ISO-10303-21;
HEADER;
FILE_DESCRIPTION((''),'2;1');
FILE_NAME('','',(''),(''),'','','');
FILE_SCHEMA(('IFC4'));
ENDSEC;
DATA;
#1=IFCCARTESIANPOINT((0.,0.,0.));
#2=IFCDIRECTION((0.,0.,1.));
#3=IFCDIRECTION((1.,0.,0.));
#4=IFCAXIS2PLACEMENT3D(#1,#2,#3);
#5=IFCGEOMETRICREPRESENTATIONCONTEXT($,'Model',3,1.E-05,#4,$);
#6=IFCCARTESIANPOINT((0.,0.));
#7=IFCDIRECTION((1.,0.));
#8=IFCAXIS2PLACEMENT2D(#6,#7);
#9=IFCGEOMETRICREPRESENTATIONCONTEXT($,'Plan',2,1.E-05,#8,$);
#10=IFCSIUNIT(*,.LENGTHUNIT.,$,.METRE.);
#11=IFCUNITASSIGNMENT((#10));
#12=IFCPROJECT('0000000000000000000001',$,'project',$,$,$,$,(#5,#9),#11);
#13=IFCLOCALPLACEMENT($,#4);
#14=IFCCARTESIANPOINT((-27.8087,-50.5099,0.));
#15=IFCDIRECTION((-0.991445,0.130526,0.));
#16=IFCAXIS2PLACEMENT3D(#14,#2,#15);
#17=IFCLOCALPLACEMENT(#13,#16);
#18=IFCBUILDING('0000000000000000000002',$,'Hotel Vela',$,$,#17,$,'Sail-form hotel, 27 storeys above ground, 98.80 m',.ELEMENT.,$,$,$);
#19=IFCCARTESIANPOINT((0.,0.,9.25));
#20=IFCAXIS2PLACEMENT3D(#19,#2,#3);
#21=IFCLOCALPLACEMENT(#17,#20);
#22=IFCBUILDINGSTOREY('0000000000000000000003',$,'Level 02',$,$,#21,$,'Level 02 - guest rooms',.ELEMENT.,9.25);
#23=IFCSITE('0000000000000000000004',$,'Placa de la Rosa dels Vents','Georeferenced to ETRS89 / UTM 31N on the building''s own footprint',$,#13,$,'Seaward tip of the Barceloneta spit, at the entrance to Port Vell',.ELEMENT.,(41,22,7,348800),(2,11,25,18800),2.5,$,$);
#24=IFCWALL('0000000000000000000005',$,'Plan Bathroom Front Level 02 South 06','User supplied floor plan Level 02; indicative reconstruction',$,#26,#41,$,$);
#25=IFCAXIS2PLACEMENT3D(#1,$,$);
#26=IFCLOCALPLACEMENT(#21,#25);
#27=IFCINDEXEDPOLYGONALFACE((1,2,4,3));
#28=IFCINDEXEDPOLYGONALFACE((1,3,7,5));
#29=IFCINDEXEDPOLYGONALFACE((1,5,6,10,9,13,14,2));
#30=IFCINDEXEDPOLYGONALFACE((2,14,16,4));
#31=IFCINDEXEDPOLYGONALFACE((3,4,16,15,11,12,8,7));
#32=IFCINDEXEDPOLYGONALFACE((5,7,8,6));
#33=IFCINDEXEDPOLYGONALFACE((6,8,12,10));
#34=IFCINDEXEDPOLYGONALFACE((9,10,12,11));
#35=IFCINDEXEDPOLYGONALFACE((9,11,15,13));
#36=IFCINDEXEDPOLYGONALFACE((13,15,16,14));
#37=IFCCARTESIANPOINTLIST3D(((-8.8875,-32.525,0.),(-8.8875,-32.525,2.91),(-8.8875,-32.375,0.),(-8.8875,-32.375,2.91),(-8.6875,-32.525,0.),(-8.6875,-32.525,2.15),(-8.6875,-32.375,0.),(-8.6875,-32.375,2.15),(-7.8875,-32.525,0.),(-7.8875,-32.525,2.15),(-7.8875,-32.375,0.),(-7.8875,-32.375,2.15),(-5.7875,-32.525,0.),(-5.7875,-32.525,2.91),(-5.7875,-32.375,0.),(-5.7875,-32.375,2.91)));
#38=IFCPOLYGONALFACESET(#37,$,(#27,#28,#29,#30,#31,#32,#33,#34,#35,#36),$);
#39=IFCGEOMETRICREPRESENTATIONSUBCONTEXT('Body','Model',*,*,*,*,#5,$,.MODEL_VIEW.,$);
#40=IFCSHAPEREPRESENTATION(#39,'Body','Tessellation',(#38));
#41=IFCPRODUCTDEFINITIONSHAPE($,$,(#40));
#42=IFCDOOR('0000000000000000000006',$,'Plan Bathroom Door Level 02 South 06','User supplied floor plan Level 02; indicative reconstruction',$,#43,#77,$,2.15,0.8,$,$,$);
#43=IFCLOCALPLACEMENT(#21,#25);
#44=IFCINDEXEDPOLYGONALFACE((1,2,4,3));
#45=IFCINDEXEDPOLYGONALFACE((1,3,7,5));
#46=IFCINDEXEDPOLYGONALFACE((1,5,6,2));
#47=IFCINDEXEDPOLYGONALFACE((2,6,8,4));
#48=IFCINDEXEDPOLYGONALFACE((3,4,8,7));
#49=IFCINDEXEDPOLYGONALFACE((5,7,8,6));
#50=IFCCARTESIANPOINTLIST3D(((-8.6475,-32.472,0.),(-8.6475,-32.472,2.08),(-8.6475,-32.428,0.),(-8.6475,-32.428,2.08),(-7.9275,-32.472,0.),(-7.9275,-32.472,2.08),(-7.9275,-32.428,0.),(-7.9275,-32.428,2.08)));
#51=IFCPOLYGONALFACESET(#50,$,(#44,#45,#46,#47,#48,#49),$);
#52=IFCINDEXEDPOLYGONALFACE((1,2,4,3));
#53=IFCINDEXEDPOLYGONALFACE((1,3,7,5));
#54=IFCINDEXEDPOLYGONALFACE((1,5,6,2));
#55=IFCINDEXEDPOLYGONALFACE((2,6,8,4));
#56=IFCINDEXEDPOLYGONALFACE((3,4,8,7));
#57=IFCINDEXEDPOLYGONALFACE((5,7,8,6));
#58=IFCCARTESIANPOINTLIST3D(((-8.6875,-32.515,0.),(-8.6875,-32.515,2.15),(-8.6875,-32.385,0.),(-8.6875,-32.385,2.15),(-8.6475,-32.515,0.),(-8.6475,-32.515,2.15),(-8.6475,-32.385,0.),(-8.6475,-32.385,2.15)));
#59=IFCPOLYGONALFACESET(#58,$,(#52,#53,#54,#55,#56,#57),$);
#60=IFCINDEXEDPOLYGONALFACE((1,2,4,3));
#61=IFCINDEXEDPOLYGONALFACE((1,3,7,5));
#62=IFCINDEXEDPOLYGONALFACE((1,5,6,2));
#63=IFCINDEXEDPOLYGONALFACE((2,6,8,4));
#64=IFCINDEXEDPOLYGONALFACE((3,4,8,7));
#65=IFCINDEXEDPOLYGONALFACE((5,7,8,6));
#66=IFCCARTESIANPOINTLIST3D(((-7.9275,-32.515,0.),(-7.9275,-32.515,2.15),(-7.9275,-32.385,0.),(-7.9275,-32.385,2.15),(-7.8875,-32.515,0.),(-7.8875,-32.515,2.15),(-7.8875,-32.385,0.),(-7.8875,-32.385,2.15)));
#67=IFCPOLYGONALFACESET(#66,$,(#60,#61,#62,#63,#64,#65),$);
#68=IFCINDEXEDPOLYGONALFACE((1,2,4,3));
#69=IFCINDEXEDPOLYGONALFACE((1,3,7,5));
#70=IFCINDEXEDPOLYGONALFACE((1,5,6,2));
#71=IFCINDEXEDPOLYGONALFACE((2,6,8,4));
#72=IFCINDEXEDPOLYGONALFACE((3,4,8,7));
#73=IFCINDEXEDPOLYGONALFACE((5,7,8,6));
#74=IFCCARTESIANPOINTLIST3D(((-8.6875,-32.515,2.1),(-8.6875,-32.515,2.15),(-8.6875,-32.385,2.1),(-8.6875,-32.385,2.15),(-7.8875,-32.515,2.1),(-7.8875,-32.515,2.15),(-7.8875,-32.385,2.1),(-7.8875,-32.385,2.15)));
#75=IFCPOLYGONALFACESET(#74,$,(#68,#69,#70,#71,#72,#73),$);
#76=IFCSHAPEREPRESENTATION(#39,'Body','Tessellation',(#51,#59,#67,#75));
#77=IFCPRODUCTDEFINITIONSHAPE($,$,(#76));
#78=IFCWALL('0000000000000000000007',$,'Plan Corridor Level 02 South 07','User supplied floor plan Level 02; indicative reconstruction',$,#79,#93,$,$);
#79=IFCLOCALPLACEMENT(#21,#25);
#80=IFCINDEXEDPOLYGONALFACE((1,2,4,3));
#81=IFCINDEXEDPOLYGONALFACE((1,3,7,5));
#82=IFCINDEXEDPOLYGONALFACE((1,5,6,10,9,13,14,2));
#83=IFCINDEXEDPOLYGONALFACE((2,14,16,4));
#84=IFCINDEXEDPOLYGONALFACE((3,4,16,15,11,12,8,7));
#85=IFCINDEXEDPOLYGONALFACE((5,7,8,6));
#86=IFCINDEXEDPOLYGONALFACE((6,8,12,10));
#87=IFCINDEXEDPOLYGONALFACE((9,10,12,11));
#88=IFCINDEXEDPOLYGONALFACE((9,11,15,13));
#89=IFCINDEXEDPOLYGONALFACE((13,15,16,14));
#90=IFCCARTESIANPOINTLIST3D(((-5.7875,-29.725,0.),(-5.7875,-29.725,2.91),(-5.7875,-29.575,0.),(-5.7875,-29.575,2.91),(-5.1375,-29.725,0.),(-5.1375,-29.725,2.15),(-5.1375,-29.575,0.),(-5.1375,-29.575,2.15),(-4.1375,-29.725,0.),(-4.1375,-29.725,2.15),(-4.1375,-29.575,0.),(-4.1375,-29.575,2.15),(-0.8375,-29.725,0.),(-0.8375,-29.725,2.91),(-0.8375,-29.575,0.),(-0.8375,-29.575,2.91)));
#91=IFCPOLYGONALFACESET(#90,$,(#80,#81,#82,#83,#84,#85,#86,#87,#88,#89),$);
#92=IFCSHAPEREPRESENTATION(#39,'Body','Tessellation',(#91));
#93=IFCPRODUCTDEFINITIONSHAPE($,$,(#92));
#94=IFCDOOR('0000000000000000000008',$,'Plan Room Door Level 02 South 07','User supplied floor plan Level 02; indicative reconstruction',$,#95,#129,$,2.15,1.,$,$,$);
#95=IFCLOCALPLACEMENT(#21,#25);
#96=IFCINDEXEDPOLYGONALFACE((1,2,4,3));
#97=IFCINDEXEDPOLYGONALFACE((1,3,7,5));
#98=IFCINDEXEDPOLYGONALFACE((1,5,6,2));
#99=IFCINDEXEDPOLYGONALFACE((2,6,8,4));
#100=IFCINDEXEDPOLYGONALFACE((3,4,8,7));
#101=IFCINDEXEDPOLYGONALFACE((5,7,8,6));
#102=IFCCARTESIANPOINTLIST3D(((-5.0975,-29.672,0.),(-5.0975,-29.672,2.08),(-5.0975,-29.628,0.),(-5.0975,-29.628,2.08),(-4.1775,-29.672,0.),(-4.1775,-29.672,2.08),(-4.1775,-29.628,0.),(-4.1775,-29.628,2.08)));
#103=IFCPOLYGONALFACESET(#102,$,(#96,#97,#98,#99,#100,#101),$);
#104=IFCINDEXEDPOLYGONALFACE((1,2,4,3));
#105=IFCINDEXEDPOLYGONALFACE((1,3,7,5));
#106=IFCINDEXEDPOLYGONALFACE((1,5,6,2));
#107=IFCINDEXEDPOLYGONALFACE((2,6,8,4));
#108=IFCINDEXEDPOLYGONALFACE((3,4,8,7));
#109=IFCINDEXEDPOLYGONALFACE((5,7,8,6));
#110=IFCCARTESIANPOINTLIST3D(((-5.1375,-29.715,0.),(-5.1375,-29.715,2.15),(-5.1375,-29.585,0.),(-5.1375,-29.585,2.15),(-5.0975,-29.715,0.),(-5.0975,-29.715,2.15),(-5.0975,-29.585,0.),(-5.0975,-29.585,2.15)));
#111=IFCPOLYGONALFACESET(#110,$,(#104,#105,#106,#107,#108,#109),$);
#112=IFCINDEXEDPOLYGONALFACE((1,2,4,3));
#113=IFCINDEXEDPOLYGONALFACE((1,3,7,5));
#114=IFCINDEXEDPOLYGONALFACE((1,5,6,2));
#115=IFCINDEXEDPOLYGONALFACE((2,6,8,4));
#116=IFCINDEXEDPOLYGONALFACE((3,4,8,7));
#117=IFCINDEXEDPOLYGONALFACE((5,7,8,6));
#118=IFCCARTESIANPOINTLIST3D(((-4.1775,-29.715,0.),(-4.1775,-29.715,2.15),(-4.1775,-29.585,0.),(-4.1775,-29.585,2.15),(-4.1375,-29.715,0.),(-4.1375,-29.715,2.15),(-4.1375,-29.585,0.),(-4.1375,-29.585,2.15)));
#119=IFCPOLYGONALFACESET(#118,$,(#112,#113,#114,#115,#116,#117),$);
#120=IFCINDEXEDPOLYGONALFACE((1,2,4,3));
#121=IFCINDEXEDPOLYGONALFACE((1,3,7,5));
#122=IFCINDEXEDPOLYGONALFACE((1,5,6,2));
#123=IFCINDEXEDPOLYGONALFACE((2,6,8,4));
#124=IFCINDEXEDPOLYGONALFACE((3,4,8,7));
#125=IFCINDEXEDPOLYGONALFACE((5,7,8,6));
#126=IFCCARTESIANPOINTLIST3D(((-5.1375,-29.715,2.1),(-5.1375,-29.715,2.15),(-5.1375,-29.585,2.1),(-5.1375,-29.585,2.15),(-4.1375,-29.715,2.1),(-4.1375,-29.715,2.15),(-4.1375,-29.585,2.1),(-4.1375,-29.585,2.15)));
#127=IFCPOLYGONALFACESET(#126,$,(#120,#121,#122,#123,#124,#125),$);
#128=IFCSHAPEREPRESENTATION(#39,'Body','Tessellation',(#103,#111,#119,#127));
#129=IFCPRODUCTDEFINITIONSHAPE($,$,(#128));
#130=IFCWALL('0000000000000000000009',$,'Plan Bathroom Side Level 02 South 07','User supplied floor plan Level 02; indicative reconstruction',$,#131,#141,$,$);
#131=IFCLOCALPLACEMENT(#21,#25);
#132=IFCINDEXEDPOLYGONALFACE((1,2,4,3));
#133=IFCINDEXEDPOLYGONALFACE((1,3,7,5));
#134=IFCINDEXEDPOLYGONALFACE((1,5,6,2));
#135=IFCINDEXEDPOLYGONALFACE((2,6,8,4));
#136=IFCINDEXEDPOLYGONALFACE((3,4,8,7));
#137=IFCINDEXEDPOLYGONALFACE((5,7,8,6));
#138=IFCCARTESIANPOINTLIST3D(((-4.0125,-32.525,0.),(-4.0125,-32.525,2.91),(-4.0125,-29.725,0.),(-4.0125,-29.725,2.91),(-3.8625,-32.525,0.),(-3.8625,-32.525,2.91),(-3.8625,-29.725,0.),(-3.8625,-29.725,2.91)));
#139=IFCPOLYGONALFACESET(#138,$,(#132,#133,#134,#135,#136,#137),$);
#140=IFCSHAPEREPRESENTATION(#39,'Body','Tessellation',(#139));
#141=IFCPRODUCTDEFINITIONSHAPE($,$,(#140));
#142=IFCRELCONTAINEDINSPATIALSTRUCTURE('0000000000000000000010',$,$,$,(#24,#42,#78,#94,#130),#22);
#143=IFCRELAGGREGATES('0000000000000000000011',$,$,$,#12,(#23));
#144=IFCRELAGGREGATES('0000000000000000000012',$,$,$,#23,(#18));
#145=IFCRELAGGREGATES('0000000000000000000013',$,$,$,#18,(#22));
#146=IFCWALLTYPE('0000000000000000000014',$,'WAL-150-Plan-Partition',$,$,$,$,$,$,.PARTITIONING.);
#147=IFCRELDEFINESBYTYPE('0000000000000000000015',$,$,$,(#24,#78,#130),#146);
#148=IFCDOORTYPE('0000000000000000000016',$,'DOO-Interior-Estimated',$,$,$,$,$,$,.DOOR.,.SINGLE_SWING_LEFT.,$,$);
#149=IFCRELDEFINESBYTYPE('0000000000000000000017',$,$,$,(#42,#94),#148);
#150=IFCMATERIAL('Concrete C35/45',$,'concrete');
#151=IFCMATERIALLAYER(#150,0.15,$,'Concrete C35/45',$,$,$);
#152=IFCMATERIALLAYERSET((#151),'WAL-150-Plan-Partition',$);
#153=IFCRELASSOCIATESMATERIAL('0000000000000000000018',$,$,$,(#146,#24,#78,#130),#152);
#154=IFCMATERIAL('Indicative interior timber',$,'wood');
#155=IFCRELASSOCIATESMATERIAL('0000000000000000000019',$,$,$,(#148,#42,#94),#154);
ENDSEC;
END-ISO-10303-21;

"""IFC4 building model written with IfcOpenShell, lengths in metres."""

from ifc_helpers import new_model, si_unit, frame, origin_with_axes, origin_2d_with_axis, place, context, subcontext, project, spatial, line, indexed_curve, outline, extrude, material, layer, layer_set, layer_usage, type_object, element, fill, save


model = new_model("IFC4")

# Units and contexts
model_context = context("Model", 3, precision=1e-05, world=origin_with_axes())
plan_context = context("Plan", 2, precision=1e-05, world=origin_2d_with_axis())
body_context = subcontext(model_context, "Body", "Model", "MODEL_VIEW")
ifc_project = project(units=[si_unit("LENGTHUNIT", "METRE")], contexts=[model_context, plan_context])

# Site, building, storey
site_placement = place(None, origin_with_axes())
site = spatial("IfcSite", under=ifc_project, at=site_placement, Name="Placa de la Rosa dels Vents", Description="Georeferenced to ETRS89 / UTM 31N on the building's own footprint", LongName="Seaward tip of the Barceloneta spit, at the entrance to Port Vell", CompositionType="ELEMENT", RefLatitude=(41, 22, 7, 348800), RefLongitude=(2, 11, 25, 18800), RefElevation=2.5)
building_placement = place(site_placement, frame((-27.8087, -50.5099, 0.0), z_axis=(0.0, 0.0, 1.0), x_axis=(-0.991445, 0.130526, 0.0)))
building = spatial("IfcBuilding", under=site, at=building_placement, Name="Hotel Vela", LongName="Sail-form hotel, 27 storeys above ground, 98.80 m", CompositionType="ELEMENT")
storey_placement = place(building_placement, frame((0.0, 0.0, 9.25), z_axis=(0.0, 0.0, 1.0), x_axis=(1.0, 0.0, 0.0)))
storey = spatial("IfcBuildingStorey", under=building, at=storey_placement, Name="Level 02", LongName="Level 02 - guest rooms", CompositionType="ELEMENT", Elevation=9.25)

# Shared definitions
ifc_material_1 = material(Name="Concrete C35/45", Category="concrete")
ifc_layer = layer(ifc_material_1, 0.15, Name="Concrete C35/45")
ifc_layer_set = layer_set([ifc_layer], Name="WAL-150-Plan-Partition")
wall_type = type_object("IfcWallType", Name="WAL-150-Plan-Partition", PredefinedType="PARTITIONING", material=ifc_layer_set)

# Shared definitions
ifc_material_2 = material(Name="Indicative interior timber", Category="wood")
door_type = type_object("IfcDoorType", Name="DOO-Interior-Estimated", OperationType="SINGLE_SWING_LEFT", PredefinedType="DOOR", material=ifc_material_2)

# Walls, openings, doors
ifc_layer_usage_1 = layer_usage(ifc_layer_set, "AXIS2", "POSITIVE", 0.0)
wall_1_placement = place(storey_placement, frame((-8.8875, -32.525, 0.0), z_axis=(0.0, 0.0, 1.0), x_axis=(1.0, 0.0, 0.0)))
wall_1 = element("IfcWall", 1, at=wall_1_placement, inside=storey, type_object=wall_type, material=ifc_layer_usage_1, Name="Plan Bathroom Front Level 02 South 06", Description="User supplied floor plan Level 02; indicative reconstruction", context=body_context, shape_type="SweptSolid", body=[
    extrude(outline(indexed_curve([(0.0, 0.0), (3.1, 0.0), (3.1, 0.15), (0.0, 0.15)], segments=[line(1, 2, 3, 4, 1)])), origin_with_axes(), (0.0, 0.0, 1.0), 2.91),
])
opening_1_placement = place(wall_1_placement, frame((0.2, -0.085, 0.0), z_axis=(0.0, 0.0, 1.0), x_axis=(1.0, 0.0, 0.0)))
opening_1 = element("IfcOpeningElement", 2, at=opening_1_placement, cuts=wall_1, PredefinedType="OPENING", context=body_context, shape_type="SweptSolid", body=[
    extrude(outline(indexed_curve([(0.0, 0.0), (0.8, 0.0), (0.8, 0.32), (0.0, 0.32)], segments=[line(1, 2, 3, 4, 1)])), origin_with_axes(), (0.0, 0.0, 1.0), 2.15),
])
door_1_placement = place(storey_placement, frame((0.0, 0.0, -9.25), z_axis=(0.0, 0.0, 1.0), x_axis=(1.0, 0.0, 0.0)))
door_1 = element("IfcDoor", 3, at=door_1_placement, inside=storey, type_object=door_type, material=ifc_material_2, Name="Plan Bathroom Door Level 02 South 06", Description="User supplied floor plan Level 02; indicative reconstruction", OverallHeight=2.15, OverallWidth=0.8, context=body_context, shape_type="SweptSolid", body=[
    extrude(outline(indexed_curve([(0.0, 0.0), (0.72, 0.0), (0.72, 0.044), (0.0, 0.044)], segments=[line(1, 2, 3, 4, 1)])), frame((-8.6475, -32.472, 9.25), z_axis=(0.0, 0.0, 1.0), x_axis=(1.0, 0.0, 0.0)), (0.0, 0.0, 1.0), 2.08),
    extrude(outline(indexed_curve([(0.0, 0.0), (0.04, 0.0), (0.04, 0.13), (0.0, 0.13)], segments=[line(1, 2, 3, 4, 1)])), frame((-8.6875, -32.515, 9.25), z_axis=(0.0, 0.0, 1.0), x_axis=(1.0, 0.0, 0.0)), (0.0, 0.0, 1.0), 2.15),
    extrude(outline(indexed_curve([(0.0, 0.0), (0.04, 0.0), (0.04, 0.13), (0.0, 0.13)], segments=[line(1, 2, 3, 4, 1)])), frame((-7.9275, -32.515, 9.25), z_axis=(0.0, 0.0, 1.0), x_axis=(1.0, 0.0, 0.0)), (0.0, 0.0, 1.0), 2.15),
    extrude(outline(indexed_curve([(0.0, 0.0), (0.8, 0.0), (0.8, 0.13), (0.0, 0.13)], segments=[line(1, 2, 3, 4, 1)])), frame((-8.6875, -32.515, 11.35), z_axis=(0.0, 0.0, 1.0), x_axis=(1.0, 0.0, 0.0)), (0.0, 0.0, 1.0), 0.05),
])
fill(opening_1, door_1)
ifc_layer_usage_2 = layer_usage(ifc_layer_set, "AXIS2", "POSITIVE", 0.0)
wall_2_placement = place(storey_placement, frame((-5.7875, -29.725, 0.0), z_axis=(0.0, 0.0, 1.0), x_axis=(1.0, 0.0, 0.0)))
wall_2 = element("IfcWall", 4, at=wall_2_placement, inside=storey, type_object=wall_type, material=ifc_layer_usage_2, Name="Plan Corridor Level 02 South 07", Description="User supplied floor plan Level 02; indicative reconstruction", context=body_context, shape_type="SweptSolid", body=[
    extrude(outline(indexed_curve([(0.0, 0.0), (4.95, 0.0), (4.95, 0.15), (0.0, 0.15)], segments=[line(1, 2, 3, 4, 1)])), origin_with_axes(), (0.0, 0.0, 1.0), 2.91),
])
opening_2_placement = place(wall_2_placement, frame((0.65, -0.085, 0.0), z_axis=(0.0, 0.0, 1.0), x_axis=(1.0, 0.0, 0.0)))
opening_2 = element("IfcOpeningElement", 5, at=opening_2_placement, cuts=wall_2, PredefinedType="OPENING", context=body_context, shape_type="SweptSolid", body=[
    extrude(outline(indexed_curve([(0.0, 0.0), (1.0, 0.0), (1.0, 0.32), (0.0, 0.32)], segments=[line(1, 2, 3, 4, 1)])), origin_with_axes(), (0.0, 0.0, 1.0), 2.15),
])
door_2_placement = place(storey_placement, frame((0.0, 0.0, -9.25), z_axis=(0.0, 0.0, 1.0), x_axis=(1.0, 0.0, 0.0)))
door_2 = element("IfcDoor", 6, at=door_2_placement, inside=storey, type_object=door_type, material=ifc_material_2, Name="Plan Room Door Level 02 South 07", Description="User supplied floor plan Level 02; indicative reconstruction", OverallHeight=2.15, OverallWidth=1.0, context=body_context, shape_type="SweptSolid", body=[
    extrude(outline(indexed_curve([(0.0, 0.0), (0.92, 0.0), (0.92, 0.044), (0.0, 0.044)], segments=[line(1, 2, 3, 4, 1)])), frame((-5.0975, -29.672, 9.25), z_axis=(0.0, 0.0, 1.0), x_axis=(1.0, 0.0, 0.0)), (0.0, 0.0, 1.0), 2.08),
    extrude(outline(indexed_curve([(0.0, 0.0), (0.04, 0.0), (0.04, 0.13), (0.0, 0.13)], segments=[line(1, 2, 3, 4, 1)])), frame((-5.1375, -29.715, 9.25), z_axis=(0.0, 0.0, 1.0), x_axis=(1.0, 0.0, 0.0)), (0.0, 0.0, 1.0), 2.15),
    extrude(outline(indexed_curve([(0.0, 0.0), (0.04, 0.0), (0.04, 0.13), (0.0, 0.13)], segments=[line(1, 2, 3, 4, 1)])), frame((-4.1775, -29.715, 9.25), z_axis=(0.0, 0.0, 1.0), x_axis=(1.0, 0.0, 0.0)), (0.0, 0.0, 1.0), 2.15),
    extrude(outline(indexed_curve([(0.0, 0.0), (1.0, 0.0), (1.0, 0.13), (0.0, 0.13)], segments=[line(1, 2, 3, 4, 1)])), frame((-5.1375, -29.715, 11.35), z_axis=(0.0, 0.0, 1.0), x_axis=(1.0, 0.0, 0.0)), (0.0, 0.0, 1.0), 0.05),
])
fill(opening_2, door_2)

# Wall
ifc_layer_usage_3 = layer_usage(ifc_layer_set, "AXIS2", "POSITIVE", 0.0)
wall_3_placement = place(storey_placement, frame((-4.0125, -32.525, 0.0), z_axis=(0.0, 0.0, 1.0), x_axis=(1.0, 0.0, 0.0)))
element("IfcWall", 7, at=wall_3_placement, inside=storey, type_object=wall_type, material=ifc_layer_usage_3, Name="Plan Bathroom Side Level 02 South 07", Description="User supplied floor plan Level 02; indicative reconstruction", context=body_context, shape_type="SweptSolid", body=[
    extrude(outline(indexed_curve([(0.0, 0.0), (0.15, 0.0), (0.15, 2.8), (0.0, 2.8)], segments=[line(1, 2, 3, 4, 1)])), origin_with_axes(), (0.0, 0.0, 1.0), 2.91),
])

save(model, "model.ifc")
